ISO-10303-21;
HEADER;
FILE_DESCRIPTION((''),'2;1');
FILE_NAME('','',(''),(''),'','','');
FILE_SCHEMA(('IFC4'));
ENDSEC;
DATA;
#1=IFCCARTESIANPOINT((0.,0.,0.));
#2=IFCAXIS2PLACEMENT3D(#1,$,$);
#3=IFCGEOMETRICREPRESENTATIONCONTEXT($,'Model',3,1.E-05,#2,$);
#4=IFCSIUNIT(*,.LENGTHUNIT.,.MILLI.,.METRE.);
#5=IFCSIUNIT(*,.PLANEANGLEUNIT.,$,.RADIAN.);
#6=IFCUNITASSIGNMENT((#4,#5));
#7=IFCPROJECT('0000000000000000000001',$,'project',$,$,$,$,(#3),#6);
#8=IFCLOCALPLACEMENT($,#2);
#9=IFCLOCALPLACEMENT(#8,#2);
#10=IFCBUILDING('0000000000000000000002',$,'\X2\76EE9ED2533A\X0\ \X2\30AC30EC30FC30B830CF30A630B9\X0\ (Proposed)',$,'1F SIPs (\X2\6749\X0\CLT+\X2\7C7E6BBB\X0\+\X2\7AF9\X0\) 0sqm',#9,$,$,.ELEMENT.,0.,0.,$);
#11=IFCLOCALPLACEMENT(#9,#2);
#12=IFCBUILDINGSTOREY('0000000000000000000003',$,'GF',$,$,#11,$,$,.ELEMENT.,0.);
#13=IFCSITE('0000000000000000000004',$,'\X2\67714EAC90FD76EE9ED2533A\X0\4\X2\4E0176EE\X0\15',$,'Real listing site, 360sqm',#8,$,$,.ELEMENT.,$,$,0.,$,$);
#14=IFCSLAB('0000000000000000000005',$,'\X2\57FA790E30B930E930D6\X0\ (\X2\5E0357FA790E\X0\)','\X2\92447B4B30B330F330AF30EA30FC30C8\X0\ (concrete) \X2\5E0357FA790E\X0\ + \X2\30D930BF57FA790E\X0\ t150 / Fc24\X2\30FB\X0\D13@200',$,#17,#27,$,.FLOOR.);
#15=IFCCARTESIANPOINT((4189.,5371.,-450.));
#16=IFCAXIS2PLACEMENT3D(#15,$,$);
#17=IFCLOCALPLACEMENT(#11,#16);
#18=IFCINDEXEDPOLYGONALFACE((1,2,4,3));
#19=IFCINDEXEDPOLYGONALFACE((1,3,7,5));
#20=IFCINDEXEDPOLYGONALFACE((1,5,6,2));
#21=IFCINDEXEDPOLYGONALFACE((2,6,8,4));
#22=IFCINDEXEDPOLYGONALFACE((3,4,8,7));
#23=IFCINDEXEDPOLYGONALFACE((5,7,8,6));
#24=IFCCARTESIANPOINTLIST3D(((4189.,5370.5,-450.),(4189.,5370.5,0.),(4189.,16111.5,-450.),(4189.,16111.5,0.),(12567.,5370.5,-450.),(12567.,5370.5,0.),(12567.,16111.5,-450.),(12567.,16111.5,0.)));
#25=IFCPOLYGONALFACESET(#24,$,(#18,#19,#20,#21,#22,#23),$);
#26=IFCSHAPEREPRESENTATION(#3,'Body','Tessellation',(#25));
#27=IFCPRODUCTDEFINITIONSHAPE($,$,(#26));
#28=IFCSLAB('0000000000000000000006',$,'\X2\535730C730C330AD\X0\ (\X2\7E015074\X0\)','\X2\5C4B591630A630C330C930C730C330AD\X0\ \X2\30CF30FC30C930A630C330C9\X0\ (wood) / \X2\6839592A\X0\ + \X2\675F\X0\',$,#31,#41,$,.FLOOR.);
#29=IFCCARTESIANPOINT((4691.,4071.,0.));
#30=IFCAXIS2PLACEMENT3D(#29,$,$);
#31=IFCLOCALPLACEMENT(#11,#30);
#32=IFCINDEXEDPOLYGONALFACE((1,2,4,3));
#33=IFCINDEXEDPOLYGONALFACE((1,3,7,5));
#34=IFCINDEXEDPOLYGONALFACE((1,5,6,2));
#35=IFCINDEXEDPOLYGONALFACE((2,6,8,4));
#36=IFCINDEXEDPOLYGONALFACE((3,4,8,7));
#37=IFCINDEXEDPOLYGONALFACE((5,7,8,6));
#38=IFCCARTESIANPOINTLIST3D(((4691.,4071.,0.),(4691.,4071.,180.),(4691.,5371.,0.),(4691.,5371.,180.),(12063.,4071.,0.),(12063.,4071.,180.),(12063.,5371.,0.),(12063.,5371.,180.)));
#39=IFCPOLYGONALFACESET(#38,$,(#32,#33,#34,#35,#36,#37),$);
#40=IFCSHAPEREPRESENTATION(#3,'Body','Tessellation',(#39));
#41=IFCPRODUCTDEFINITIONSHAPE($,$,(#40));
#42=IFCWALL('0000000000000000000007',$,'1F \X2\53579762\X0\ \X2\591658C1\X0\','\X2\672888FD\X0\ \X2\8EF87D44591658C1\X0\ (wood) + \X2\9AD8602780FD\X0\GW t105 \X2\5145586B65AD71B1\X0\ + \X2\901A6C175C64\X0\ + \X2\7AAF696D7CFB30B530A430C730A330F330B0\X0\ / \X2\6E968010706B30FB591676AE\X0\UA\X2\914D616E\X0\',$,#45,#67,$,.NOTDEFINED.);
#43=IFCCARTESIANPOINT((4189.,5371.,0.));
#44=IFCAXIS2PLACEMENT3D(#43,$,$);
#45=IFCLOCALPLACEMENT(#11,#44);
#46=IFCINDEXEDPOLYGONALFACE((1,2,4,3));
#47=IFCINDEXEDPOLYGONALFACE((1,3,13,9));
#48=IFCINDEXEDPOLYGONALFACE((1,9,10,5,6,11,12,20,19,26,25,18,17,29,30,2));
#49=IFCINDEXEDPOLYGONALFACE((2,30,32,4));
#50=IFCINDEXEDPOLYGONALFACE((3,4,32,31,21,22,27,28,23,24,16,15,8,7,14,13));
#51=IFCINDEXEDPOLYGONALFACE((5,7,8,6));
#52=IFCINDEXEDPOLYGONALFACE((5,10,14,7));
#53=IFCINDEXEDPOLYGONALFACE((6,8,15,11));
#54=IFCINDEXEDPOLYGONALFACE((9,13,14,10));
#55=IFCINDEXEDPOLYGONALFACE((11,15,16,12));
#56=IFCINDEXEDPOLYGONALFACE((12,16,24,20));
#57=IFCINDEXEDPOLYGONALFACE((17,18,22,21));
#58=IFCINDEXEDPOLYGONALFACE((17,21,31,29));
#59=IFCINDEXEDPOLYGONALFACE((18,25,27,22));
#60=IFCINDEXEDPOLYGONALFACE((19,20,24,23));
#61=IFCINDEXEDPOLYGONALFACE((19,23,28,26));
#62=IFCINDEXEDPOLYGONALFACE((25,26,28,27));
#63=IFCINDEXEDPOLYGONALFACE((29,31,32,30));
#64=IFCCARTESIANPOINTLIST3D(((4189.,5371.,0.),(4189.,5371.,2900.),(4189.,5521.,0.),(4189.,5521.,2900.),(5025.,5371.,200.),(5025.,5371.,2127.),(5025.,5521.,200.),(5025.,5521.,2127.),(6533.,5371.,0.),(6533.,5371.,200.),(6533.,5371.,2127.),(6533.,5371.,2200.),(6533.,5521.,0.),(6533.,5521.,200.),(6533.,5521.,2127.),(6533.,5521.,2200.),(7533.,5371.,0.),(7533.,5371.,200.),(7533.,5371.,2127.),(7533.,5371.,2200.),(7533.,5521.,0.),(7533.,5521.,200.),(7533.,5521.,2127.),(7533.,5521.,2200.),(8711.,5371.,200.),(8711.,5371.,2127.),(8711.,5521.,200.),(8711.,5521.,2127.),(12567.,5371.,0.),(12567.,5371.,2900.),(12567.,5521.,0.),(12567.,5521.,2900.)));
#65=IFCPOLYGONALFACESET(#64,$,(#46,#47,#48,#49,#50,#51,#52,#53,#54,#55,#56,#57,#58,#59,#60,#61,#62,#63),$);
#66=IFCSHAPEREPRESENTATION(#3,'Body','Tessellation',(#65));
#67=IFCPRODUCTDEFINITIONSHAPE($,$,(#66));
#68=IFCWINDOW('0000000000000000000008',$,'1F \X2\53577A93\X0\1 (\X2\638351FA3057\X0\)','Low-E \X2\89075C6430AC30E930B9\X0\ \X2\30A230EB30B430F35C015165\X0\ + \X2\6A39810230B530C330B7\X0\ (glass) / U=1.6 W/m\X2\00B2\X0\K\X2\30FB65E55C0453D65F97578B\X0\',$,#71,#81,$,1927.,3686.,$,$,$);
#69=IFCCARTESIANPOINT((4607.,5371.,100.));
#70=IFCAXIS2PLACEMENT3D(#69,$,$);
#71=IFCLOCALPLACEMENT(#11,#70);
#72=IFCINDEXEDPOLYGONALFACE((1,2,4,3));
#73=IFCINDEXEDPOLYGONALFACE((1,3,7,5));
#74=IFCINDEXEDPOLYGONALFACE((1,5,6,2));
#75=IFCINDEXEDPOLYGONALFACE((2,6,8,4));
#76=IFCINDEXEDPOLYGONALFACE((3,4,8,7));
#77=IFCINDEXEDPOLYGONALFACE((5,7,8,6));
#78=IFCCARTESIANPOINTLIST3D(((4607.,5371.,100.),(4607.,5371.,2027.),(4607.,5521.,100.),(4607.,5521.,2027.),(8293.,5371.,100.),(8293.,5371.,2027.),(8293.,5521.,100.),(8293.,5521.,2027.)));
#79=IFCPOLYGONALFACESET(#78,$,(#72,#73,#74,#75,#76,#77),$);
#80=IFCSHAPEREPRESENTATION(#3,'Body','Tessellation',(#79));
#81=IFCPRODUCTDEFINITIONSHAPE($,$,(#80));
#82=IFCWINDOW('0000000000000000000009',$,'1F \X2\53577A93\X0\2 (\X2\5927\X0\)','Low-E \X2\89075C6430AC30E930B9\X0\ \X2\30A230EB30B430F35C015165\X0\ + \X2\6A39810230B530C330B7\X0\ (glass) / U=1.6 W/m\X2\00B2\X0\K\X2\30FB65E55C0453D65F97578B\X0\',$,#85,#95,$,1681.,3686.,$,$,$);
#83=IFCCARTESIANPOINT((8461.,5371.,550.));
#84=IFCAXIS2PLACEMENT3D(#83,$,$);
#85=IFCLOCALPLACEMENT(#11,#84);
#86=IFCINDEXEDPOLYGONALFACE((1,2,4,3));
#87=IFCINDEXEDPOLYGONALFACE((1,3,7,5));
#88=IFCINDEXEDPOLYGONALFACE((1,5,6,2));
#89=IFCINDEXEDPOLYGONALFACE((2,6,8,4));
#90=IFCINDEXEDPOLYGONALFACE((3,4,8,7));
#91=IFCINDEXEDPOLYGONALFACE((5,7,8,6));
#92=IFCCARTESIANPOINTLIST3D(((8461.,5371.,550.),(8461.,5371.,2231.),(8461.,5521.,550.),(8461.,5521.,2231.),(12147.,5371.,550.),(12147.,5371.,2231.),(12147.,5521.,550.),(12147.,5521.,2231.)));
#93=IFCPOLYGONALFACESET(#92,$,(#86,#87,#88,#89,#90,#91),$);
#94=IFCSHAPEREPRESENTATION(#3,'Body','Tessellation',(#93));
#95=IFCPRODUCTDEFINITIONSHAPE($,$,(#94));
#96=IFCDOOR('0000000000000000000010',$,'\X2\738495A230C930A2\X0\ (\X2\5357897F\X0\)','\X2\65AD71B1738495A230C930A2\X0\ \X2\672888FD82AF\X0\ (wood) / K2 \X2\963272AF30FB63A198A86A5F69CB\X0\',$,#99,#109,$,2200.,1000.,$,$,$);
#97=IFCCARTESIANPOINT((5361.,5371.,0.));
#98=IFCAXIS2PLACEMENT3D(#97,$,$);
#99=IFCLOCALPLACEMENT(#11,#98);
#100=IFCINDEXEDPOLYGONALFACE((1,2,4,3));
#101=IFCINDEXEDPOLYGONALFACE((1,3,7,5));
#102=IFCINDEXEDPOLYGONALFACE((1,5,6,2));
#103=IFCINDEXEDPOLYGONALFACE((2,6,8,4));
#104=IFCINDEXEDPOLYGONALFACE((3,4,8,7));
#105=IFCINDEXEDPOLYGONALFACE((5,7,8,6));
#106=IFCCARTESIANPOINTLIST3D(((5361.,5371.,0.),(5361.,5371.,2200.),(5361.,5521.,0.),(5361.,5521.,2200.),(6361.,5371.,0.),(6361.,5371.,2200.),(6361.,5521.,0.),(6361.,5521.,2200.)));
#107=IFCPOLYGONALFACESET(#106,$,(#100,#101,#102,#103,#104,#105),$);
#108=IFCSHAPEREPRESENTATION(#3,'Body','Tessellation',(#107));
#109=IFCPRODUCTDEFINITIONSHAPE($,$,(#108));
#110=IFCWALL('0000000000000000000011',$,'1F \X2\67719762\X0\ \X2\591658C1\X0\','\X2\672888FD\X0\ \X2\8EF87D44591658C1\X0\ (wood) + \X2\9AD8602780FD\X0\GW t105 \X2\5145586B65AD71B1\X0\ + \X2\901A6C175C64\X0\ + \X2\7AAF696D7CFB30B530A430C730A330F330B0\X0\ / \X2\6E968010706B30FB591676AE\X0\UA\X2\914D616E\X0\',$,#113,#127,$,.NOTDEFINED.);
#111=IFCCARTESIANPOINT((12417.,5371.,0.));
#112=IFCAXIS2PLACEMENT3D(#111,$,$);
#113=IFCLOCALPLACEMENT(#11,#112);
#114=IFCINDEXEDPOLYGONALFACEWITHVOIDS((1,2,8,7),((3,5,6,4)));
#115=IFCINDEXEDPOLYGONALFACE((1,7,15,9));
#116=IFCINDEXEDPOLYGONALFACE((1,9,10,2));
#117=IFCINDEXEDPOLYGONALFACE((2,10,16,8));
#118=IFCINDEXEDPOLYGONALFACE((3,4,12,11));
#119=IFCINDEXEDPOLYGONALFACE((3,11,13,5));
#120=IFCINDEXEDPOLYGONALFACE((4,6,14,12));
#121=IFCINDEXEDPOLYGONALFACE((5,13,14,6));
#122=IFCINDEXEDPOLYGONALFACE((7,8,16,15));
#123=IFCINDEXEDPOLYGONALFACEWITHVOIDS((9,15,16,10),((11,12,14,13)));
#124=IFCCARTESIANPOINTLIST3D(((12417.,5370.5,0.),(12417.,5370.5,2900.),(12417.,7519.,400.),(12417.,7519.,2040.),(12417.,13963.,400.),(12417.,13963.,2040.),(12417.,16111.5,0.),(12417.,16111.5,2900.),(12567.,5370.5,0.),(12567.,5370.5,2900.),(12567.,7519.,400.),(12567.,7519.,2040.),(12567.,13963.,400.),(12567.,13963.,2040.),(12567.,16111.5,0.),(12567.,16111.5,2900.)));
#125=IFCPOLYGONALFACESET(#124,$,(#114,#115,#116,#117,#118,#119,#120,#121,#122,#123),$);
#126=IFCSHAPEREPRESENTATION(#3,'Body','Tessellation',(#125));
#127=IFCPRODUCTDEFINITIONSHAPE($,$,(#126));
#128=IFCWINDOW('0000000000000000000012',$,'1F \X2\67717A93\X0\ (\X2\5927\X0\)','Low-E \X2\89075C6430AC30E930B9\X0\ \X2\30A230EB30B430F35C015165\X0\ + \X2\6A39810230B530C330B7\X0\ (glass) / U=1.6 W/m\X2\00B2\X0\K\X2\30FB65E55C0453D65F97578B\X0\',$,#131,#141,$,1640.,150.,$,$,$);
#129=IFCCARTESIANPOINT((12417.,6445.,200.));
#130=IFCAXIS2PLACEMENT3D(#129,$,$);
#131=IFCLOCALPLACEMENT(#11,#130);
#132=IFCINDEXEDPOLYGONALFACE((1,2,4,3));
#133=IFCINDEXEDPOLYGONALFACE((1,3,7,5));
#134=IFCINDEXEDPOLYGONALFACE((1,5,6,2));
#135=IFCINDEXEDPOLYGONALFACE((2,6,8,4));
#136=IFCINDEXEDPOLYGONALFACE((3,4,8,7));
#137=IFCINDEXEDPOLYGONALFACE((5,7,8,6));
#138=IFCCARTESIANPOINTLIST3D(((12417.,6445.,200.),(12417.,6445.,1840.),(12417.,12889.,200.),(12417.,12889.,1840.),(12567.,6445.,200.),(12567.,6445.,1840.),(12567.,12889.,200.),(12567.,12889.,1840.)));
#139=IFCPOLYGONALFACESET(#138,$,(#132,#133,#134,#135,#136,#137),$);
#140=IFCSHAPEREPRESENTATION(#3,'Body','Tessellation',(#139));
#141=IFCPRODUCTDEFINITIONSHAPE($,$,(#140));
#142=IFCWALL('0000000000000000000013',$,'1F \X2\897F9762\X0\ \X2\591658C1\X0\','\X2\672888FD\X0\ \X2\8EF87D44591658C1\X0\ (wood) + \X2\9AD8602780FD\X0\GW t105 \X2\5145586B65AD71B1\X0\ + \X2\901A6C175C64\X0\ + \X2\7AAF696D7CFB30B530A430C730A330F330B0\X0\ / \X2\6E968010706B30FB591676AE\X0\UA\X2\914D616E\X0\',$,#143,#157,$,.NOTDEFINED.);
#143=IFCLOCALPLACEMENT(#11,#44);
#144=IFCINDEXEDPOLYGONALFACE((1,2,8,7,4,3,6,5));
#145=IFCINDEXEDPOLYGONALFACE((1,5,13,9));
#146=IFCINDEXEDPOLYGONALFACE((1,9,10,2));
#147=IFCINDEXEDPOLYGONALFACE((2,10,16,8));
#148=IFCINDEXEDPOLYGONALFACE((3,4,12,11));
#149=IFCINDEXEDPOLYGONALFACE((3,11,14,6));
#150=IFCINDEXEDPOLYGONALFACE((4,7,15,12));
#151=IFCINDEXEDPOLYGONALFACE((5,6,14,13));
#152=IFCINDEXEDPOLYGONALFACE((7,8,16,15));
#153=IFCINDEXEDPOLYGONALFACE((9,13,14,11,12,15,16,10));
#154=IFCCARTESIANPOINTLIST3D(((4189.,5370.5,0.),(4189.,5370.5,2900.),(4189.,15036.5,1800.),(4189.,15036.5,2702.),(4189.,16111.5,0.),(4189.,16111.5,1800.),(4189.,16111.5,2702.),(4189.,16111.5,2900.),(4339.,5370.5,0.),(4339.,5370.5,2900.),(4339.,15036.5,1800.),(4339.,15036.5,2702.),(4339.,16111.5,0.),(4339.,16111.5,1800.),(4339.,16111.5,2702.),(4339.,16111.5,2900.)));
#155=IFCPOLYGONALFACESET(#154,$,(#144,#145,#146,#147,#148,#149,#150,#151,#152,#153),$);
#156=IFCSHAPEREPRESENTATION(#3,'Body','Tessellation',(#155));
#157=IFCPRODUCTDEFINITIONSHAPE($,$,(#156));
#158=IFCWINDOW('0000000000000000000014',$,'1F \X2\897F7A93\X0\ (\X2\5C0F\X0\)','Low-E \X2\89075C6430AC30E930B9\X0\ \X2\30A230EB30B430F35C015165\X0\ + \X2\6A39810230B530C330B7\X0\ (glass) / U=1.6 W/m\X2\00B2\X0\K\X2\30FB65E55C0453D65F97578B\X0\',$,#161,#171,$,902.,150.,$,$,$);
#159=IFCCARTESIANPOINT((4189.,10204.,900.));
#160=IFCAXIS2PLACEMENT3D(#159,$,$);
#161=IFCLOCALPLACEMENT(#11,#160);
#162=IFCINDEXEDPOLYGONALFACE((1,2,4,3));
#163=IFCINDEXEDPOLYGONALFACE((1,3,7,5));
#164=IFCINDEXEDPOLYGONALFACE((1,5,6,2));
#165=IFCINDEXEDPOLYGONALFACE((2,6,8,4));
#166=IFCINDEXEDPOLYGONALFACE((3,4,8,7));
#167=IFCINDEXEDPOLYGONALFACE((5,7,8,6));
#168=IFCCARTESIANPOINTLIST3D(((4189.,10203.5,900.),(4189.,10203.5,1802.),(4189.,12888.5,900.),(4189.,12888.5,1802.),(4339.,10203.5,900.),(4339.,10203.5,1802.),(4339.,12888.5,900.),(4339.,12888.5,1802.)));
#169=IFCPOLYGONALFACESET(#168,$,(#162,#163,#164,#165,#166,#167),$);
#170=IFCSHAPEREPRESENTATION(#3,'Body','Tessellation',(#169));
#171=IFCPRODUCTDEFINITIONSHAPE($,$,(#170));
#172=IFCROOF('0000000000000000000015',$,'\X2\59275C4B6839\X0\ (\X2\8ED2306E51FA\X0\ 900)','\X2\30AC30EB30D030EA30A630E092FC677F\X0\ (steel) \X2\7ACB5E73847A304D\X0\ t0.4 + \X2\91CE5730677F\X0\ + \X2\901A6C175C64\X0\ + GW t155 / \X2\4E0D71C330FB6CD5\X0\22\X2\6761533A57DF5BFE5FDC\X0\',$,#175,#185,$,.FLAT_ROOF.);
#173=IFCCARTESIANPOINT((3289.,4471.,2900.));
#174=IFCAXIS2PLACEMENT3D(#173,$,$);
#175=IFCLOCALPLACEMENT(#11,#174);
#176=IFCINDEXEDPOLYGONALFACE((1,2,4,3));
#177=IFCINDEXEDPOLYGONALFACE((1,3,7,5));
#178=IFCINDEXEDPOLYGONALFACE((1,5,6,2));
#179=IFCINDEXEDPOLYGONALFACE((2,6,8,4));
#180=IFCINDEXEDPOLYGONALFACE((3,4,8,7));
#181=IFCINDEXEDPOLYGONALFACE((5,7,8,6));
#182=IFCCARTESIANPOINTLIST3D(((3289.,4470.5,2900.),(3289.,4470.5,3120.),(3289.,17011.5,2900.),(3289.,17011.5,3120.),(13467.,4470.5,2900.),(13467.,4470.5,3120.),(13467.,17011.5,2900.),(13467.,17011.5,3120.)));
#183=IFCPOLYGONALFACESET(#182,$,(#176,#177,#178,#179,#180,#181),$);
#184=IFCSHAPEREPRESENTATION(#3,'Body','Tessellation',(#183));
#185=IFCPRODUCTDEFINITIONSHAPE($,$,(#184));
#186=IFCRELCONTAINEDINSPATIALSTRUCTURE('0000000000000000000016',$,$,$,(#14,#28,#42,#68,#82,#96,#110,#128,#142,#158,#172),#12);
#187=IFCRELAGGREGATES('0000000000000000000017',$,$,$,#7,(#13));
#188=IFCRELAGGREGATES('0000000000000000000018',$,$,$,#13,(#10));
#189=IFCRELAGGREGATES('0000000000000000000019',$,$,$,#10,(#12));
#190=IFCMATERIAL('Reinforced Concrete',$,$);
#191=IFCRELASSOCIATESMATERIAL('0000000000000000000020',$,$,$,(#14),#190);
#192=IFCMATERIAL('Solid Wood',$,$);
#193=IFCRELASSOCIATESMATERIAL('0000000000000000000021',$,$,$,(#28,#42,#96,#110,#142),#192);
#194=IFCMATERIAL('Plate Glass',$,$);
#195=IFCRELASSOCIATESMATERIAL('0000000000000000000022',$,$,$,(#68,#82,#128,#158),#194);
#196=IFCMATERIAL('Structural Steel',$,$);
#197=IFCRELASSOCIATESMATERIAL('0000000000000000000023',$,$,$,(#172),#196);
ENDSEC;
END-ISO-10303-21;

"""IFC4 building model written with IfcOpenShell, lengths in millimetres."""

from ifc_helpers import new_model, si_unit, frame, frame_2d, origin, place, context, project, spatial, rectangle, extrude, material, element, fill, save


model = new_model("IFC4")

# Units and contexts
model_context = context("Model", 3, precision=1e-05, world=origin())
ifc_project = project(units=[si_unit("LENGTHUNIT", "METRE", prefix="MILLI"), si_unit("PLANEANGLEUNIT", "RADIAN")], contexts=[model_context])

# Site, building, storey
site_placement = place(None, origin())
site = spatial("IfcSite", under=ifc_project, at=site_placement, Name="東京都目黒区4丁目15", ObjectType="Real listing site, 360sqm", CompositionType="ELEMENT", RefElevation=0.0)
building_placement = place(site_placement, origin())
building = spatial("IfcBuilding", under=site, at=building_placement, Name="目黒区 ガレージハウス (Proposed)", ObjectType="1F SIPs (杉CLT+籾殻+竹) 0sqm", CompositionType="ELEMENT", ElevationOfRefHeight=0.0, ElevationOfTerrain=0.0)
storey_placement = place(building_placement, origin())
storey = spatial("IfcBuildingStorey", under=building, at=storey_placement, Name="GF", CompositionType="ELEMENT", Elevation=0.0)

# Slabs
ifc_material_1 = material(Name="Reinforced Concrete")
slab_1_placement = place(storey_placement, frame((4189.0, 5371.0, -450.0)))
element("IfcSlab", 1, at=slab_1_placement, inside=storey, material=ifc_material_1, Name="基礎スラブ (布基礎)", Description="鉄筋コンクリート (concrete) 布基礎 + ベタ基礎 t150 / Fc24・D13@200", PredefinedType="FLOOR", context=model_context, shape_type="SweptSolid", body=[
    extrude(rectangle(XDim=8378.0, YDim=10741.0, at=frame_2d((4189.0, 5370.0))), frame((4189.0, 5371.0, -450.0)), (0.0, 0.0, 1.0), 450.0),
])
ifc_material_2 = material(Name="Solid Wood")
slab_2_placement = place(storey_placement, frame((4691.0, 4071.0, 0.0)))
element("IfcSlab", 2, at=slab_2_placement, inside=storey, material=ifc_material_2, Name="南デッキ (縁側)", Description="屋外ウッドデッキ ハードウッド (wood) / 根太 + 束", PredefinedType="FLOOR", context=model_context, shape_type="SweptSolid", body=[
    extrude(rectangle(XDim=7372.0, YDim=1300.0, at=frame_2d((3686.0, 650.0))), frame((4691.0, 4071.0, 0.0)), (0.0, 0.0, 1.0), 180.0),
])

# Wall, openings, windows, door
wall_1_placement = place(storey_placement, frame((4189.0, 5371.0, 0.0)))
wall_1 = element("IfcWall", 3, at=wall_1_placement, inside=storey, material=ifc_material_2, Name="1F 南面 外壁", Description="木製 軸組外壁 (wood) + 高性能GW t105 充填断熱 + 通気層 + 窯業系サイディング / 準耐火・外皮UA配慮", PredefinedType="NOTDEFINED", context=model_context, shape_type="SweptSolid", body=[
    extrude(rectangle(XDim=8378.0, YDim=150.0, at=frame_2d((4189.0, 75.0))), frame((4189.0, 5371.0, 0.0)), (0.0, 0.0, 1.0), 2900.0),
])
opening_1_placement = place(storey_placement, frame((4607.0, 5371.0, 100.0)))
opening_1 = element("IfcOpeningElement", 4, at=opening_1_placement, cuts=wall_1, PredefinedType="NOTDEFINED", context=model_context, shape_type="SweptSolid", body=[
    extrude(rectangle(XDim=3686.0, YDim=150.0, at=frame_2d((1843.0, 75.0))), frame((4607.0, 5371.0, 100.0)), (0.0, 0.0, 1.0), 1927.0),
])
opening_2_placement = place(storey_placement, frame((8461.0, 5371.0, 550.0)))
opening_2 = element("IfcOpeningElement", 5, at=opening_2_placement, cuts=wall_1, PredefinedType="NOTDEFINED", context=model_context, shape_type="SweptSolid", body=[
    extrude(rectangle(XDim=3686.0, YDim=150.0, at=frame_2d((1843.0, 75.0))), frame((8461.0, 5371.0, 550.0)), (0.0, 0.0, 1.0), 1681.0),
])
opening_3_placement = place(storey_placement, frame((5361.0, 5371.0, 0.0)))
opening_3 = element("IfcOpeningElement", 6, at=opening_3_placement, cuts=wall_1, PredefinedType="NOTDEFINED", context=model_context, shape_type="SweptSolid", body=[
    extrude(rectangle(XDim=1000.0, YDim=150.0, at=frame_2d((500.0, 75.0))), frame((5361.0, 5371.0, 0.0)), (0.0, 0.0, 1.0), 2200.0),
])
ifc_material_3 = material(Name="Plate Glass")
window_1_placement = place(storey_placement, frame((4607.0, 5371.0, 100.0)))
window_1 = element("IfcWindow", 7, at=window_1_placement, inside=storey, material=ifc_material_3, Name="1F 南窓1 (掃出し)", Description="Low-E 複層ガラス アルゴン封入 + 樹脂サッシ (glass) / U=1.6 W/m²K・日射取得型", OverallHeight=1927.0, OverallWidth=3686.0, context=model_context, shape_type="SweptSolid", body=[
    extrude(rectangle(XDim=3686.0, YDim=150.0, at=frame_2d((1843.0, 75.0))), frame((4607.0, 5371.0, 100.0)), (0.0, 0.0, 1.0), 1927.0),
])
fill(opening_1, window_1)
window_2_placement = place(storey_placement, frame((8461.0, 5371.0, 550.0)))
window_2 = element("IfcWindow", 8, at=window_2_placement, inside=storey, material=ifc_material_3, Name="1F 南窓2 (大)", Description="Low-E 複層ガラス アルゴン封入 + 樹脂サッシ (glass) / U=1.6 W/m²K・日射取得型", OverallHeight=1681.0, OverallWidth=3686.0, context=model_context, shape_type="SweptSolid", body=[
    extrude(rectangle(XDim=3686.0, YDim=150.0, at=frame_2d((1843.0, 75.0))), frame((8461.0, 5371.0, 550.0)), (0.0, 0.0, 1.0), 1681.0),
])
fill(opening_2, window_2)
door_placement = place(storey_placement, frame((5361.0, 5371.0, 0.0)))
door = element("IfcDoor", 9, at=door_placement, inside=storey, material=ifc_material_2, Name="玄関ドア (南西)", Description="断熱玄関ドア 木製芯 (wood) / K2 防犯・採風機構", OverallHeight=2200.0, OverallWidth=1000.0, context=model_context, shape_type="SweptSolid", body=[
    extrude(rectangle(XDim=1000.0, YDim=150.0, at=frame_2d((500.0, 75.0))), frame((5361.0, 5371.0, 0.0)), (0.0, 0.0, 1.0), 2200.0),
])
fill(opening_3, door)

# Walls, openings, windows
wall_2_placement = place(storey_placement, frame((12417.0, 5371.0, 0.0)))
wall_2 = element("IfcWall", 10, at=wall_2_placement, inside=storey, material=ifc_material_2, Name="1F 東面 外壁", Description="木製 軸組外壁 (wood) + 高性能GW t105 充填断熱 + 通気層 + 窯業系サイディング / 準耐火・外皮UA配慮", PredefinedType="NOTDEFINED", context=model_context, shape_type="SweptSolid", body=[
    extrude(rectangle(XDim=150.0, YDim=10741.0, at=frame_2d((75.0, 5370.0))), frame((12417.0, 5371.0, 0.0)), (0.0, 0.0, 1.0), 2900.0),
])
opening_4_placement = place(storey_placement, frame((12417.0, 6445.0, 200.0)))
opening_4 = element("IfcOpeningElement", 11, at=opening_4_placement, cuts=wall_2, PredefinedType="NOTDEFINED", context=model_context, shape_type="SweptSolid", body=[
    extrude(rectangle(XDim=150.0, YDim=6444.0, at=frame_2d((75.0, 3222.0))), frame((12417.0, 6445.0, 200.0)), (0.0, 0.0, 1.0), 1640.0),
])
window_3_placement = place(storey_placement, frame((12417.0, 6445.0, 200.0)))
window_3 = element("IfcWindow", 12, at=window_3_placement, inside=storey, material=ifc_material_3, Name="1F 東窓 (大)", Description="Low-E 複層ガラス アルゴン封入 + 樹脂サッシ (glass) / U=1.6 W/m²K・日射取得型", OverallHeight=1640.0, OverallWidth=150.0, context=model_context, shape_type="SweptSolid", body=[
    extrude(rectangle(XDim=150.0, YDim=6444.0, at=frame_2d((75.0, 3222.0))), frame((12417.0, 6445.0, 200.0)), (0.0, 0.0, 1.0), 1640.0),
])
fill(opening_4, window_3)
wall_3_placement = place(storey_placement, frame((4189.0, 5371.0, 0.0)))
wall_3 = element("IfcWall", 13, at=wall_3_placement, inside=storey, material=ifc_material_2, Name="1F 西面 外壁", Description="木製 軸組外壁 (wood) + 高性能GW t105 充填断熱 + 通気層 + 窯業系サイディング / 準耐火・外皮UA配慮", PredefinedType="NOTDEFINED", context=model_context, shape_type="SweptSolid", body=[
    extrude(rectangle(XDim=150.0, YDim=10741.0, at=frame_2d((75.0, 5370.0))), frame((4189.0, 5371.0, 0.0)), (0.0, 0.0, 1.0), 2900.0),
])
opening_5_placement = place(storey_placement, frame((4189.0, 10204.0, 900.0)))
opening_5 = element("IfcOpeningElement", 14, at=opening_5_placement, cuts=wall_3, PredefinedType="NOTDEFINED", context=model_context, shape_type="SweptSolid", body=[
    extrude(rectangle(XDim=150.0, YDim=2685.0, at=frame_2d((75.0, 1342.0))), frame((4189.0, 10204.0, 900.0)), (0.0, 0.0, 1.0), 902.0),
])
window_4_placement = place(storey_placement, frame((4189.0, 10204.0, 900.0)))
window_4 = element("IfcWindow", 15, at=window_4_placement, inside=storey, material=ifc_material_3, Name="1F 西窓 (小)", Description="Low-E 複層ガラス アルゴン封入 + 樹脂サッシ (glass) / U=1.6 W/m²K・日射取得型", OverallHeight=902.0, OverallWidth=150.0, context=model_context, shape_type="SweptSolid", body=[
    extrude(rectangle(XDim=150.0, YDim=2685.0, at=frame_2d((75.0, 1342.0))), frame((4189.0, 10204.0, 900.0)), (0.0, 0.0, 1.0), 902.0),
])
fill(opening_5, window_4)

# Roof
ifc_material_4 = material(Name="Structural Steel")
roof_placement = place(storey_placement, frame((3289.0, 4471.0, 2900.0)))
element("IfcRoof", 16, at=roof_placement, inside=storey, material=ifc_material_4, Name="大屋根 (軒の出 900)", Description="ガルバリウム鋼板 (steel) 立平葺き t0.4 + 野地板 + 通気層 + GW t155 / 不燃・法22条区域対応", PredefinedType="FLAT_ROOF", context=model_context, shape_type="SweptSolid", body=[
    extrude(rectangle(XDim=10178.0, YDim=12541.0, at=frame_2d((5089.0, 6270.0))), frame((3289.0, 4471.0, 2900.0)), (0.0, 0.0, 1.0), 220.0),
])

save(model, "model.ifc")
